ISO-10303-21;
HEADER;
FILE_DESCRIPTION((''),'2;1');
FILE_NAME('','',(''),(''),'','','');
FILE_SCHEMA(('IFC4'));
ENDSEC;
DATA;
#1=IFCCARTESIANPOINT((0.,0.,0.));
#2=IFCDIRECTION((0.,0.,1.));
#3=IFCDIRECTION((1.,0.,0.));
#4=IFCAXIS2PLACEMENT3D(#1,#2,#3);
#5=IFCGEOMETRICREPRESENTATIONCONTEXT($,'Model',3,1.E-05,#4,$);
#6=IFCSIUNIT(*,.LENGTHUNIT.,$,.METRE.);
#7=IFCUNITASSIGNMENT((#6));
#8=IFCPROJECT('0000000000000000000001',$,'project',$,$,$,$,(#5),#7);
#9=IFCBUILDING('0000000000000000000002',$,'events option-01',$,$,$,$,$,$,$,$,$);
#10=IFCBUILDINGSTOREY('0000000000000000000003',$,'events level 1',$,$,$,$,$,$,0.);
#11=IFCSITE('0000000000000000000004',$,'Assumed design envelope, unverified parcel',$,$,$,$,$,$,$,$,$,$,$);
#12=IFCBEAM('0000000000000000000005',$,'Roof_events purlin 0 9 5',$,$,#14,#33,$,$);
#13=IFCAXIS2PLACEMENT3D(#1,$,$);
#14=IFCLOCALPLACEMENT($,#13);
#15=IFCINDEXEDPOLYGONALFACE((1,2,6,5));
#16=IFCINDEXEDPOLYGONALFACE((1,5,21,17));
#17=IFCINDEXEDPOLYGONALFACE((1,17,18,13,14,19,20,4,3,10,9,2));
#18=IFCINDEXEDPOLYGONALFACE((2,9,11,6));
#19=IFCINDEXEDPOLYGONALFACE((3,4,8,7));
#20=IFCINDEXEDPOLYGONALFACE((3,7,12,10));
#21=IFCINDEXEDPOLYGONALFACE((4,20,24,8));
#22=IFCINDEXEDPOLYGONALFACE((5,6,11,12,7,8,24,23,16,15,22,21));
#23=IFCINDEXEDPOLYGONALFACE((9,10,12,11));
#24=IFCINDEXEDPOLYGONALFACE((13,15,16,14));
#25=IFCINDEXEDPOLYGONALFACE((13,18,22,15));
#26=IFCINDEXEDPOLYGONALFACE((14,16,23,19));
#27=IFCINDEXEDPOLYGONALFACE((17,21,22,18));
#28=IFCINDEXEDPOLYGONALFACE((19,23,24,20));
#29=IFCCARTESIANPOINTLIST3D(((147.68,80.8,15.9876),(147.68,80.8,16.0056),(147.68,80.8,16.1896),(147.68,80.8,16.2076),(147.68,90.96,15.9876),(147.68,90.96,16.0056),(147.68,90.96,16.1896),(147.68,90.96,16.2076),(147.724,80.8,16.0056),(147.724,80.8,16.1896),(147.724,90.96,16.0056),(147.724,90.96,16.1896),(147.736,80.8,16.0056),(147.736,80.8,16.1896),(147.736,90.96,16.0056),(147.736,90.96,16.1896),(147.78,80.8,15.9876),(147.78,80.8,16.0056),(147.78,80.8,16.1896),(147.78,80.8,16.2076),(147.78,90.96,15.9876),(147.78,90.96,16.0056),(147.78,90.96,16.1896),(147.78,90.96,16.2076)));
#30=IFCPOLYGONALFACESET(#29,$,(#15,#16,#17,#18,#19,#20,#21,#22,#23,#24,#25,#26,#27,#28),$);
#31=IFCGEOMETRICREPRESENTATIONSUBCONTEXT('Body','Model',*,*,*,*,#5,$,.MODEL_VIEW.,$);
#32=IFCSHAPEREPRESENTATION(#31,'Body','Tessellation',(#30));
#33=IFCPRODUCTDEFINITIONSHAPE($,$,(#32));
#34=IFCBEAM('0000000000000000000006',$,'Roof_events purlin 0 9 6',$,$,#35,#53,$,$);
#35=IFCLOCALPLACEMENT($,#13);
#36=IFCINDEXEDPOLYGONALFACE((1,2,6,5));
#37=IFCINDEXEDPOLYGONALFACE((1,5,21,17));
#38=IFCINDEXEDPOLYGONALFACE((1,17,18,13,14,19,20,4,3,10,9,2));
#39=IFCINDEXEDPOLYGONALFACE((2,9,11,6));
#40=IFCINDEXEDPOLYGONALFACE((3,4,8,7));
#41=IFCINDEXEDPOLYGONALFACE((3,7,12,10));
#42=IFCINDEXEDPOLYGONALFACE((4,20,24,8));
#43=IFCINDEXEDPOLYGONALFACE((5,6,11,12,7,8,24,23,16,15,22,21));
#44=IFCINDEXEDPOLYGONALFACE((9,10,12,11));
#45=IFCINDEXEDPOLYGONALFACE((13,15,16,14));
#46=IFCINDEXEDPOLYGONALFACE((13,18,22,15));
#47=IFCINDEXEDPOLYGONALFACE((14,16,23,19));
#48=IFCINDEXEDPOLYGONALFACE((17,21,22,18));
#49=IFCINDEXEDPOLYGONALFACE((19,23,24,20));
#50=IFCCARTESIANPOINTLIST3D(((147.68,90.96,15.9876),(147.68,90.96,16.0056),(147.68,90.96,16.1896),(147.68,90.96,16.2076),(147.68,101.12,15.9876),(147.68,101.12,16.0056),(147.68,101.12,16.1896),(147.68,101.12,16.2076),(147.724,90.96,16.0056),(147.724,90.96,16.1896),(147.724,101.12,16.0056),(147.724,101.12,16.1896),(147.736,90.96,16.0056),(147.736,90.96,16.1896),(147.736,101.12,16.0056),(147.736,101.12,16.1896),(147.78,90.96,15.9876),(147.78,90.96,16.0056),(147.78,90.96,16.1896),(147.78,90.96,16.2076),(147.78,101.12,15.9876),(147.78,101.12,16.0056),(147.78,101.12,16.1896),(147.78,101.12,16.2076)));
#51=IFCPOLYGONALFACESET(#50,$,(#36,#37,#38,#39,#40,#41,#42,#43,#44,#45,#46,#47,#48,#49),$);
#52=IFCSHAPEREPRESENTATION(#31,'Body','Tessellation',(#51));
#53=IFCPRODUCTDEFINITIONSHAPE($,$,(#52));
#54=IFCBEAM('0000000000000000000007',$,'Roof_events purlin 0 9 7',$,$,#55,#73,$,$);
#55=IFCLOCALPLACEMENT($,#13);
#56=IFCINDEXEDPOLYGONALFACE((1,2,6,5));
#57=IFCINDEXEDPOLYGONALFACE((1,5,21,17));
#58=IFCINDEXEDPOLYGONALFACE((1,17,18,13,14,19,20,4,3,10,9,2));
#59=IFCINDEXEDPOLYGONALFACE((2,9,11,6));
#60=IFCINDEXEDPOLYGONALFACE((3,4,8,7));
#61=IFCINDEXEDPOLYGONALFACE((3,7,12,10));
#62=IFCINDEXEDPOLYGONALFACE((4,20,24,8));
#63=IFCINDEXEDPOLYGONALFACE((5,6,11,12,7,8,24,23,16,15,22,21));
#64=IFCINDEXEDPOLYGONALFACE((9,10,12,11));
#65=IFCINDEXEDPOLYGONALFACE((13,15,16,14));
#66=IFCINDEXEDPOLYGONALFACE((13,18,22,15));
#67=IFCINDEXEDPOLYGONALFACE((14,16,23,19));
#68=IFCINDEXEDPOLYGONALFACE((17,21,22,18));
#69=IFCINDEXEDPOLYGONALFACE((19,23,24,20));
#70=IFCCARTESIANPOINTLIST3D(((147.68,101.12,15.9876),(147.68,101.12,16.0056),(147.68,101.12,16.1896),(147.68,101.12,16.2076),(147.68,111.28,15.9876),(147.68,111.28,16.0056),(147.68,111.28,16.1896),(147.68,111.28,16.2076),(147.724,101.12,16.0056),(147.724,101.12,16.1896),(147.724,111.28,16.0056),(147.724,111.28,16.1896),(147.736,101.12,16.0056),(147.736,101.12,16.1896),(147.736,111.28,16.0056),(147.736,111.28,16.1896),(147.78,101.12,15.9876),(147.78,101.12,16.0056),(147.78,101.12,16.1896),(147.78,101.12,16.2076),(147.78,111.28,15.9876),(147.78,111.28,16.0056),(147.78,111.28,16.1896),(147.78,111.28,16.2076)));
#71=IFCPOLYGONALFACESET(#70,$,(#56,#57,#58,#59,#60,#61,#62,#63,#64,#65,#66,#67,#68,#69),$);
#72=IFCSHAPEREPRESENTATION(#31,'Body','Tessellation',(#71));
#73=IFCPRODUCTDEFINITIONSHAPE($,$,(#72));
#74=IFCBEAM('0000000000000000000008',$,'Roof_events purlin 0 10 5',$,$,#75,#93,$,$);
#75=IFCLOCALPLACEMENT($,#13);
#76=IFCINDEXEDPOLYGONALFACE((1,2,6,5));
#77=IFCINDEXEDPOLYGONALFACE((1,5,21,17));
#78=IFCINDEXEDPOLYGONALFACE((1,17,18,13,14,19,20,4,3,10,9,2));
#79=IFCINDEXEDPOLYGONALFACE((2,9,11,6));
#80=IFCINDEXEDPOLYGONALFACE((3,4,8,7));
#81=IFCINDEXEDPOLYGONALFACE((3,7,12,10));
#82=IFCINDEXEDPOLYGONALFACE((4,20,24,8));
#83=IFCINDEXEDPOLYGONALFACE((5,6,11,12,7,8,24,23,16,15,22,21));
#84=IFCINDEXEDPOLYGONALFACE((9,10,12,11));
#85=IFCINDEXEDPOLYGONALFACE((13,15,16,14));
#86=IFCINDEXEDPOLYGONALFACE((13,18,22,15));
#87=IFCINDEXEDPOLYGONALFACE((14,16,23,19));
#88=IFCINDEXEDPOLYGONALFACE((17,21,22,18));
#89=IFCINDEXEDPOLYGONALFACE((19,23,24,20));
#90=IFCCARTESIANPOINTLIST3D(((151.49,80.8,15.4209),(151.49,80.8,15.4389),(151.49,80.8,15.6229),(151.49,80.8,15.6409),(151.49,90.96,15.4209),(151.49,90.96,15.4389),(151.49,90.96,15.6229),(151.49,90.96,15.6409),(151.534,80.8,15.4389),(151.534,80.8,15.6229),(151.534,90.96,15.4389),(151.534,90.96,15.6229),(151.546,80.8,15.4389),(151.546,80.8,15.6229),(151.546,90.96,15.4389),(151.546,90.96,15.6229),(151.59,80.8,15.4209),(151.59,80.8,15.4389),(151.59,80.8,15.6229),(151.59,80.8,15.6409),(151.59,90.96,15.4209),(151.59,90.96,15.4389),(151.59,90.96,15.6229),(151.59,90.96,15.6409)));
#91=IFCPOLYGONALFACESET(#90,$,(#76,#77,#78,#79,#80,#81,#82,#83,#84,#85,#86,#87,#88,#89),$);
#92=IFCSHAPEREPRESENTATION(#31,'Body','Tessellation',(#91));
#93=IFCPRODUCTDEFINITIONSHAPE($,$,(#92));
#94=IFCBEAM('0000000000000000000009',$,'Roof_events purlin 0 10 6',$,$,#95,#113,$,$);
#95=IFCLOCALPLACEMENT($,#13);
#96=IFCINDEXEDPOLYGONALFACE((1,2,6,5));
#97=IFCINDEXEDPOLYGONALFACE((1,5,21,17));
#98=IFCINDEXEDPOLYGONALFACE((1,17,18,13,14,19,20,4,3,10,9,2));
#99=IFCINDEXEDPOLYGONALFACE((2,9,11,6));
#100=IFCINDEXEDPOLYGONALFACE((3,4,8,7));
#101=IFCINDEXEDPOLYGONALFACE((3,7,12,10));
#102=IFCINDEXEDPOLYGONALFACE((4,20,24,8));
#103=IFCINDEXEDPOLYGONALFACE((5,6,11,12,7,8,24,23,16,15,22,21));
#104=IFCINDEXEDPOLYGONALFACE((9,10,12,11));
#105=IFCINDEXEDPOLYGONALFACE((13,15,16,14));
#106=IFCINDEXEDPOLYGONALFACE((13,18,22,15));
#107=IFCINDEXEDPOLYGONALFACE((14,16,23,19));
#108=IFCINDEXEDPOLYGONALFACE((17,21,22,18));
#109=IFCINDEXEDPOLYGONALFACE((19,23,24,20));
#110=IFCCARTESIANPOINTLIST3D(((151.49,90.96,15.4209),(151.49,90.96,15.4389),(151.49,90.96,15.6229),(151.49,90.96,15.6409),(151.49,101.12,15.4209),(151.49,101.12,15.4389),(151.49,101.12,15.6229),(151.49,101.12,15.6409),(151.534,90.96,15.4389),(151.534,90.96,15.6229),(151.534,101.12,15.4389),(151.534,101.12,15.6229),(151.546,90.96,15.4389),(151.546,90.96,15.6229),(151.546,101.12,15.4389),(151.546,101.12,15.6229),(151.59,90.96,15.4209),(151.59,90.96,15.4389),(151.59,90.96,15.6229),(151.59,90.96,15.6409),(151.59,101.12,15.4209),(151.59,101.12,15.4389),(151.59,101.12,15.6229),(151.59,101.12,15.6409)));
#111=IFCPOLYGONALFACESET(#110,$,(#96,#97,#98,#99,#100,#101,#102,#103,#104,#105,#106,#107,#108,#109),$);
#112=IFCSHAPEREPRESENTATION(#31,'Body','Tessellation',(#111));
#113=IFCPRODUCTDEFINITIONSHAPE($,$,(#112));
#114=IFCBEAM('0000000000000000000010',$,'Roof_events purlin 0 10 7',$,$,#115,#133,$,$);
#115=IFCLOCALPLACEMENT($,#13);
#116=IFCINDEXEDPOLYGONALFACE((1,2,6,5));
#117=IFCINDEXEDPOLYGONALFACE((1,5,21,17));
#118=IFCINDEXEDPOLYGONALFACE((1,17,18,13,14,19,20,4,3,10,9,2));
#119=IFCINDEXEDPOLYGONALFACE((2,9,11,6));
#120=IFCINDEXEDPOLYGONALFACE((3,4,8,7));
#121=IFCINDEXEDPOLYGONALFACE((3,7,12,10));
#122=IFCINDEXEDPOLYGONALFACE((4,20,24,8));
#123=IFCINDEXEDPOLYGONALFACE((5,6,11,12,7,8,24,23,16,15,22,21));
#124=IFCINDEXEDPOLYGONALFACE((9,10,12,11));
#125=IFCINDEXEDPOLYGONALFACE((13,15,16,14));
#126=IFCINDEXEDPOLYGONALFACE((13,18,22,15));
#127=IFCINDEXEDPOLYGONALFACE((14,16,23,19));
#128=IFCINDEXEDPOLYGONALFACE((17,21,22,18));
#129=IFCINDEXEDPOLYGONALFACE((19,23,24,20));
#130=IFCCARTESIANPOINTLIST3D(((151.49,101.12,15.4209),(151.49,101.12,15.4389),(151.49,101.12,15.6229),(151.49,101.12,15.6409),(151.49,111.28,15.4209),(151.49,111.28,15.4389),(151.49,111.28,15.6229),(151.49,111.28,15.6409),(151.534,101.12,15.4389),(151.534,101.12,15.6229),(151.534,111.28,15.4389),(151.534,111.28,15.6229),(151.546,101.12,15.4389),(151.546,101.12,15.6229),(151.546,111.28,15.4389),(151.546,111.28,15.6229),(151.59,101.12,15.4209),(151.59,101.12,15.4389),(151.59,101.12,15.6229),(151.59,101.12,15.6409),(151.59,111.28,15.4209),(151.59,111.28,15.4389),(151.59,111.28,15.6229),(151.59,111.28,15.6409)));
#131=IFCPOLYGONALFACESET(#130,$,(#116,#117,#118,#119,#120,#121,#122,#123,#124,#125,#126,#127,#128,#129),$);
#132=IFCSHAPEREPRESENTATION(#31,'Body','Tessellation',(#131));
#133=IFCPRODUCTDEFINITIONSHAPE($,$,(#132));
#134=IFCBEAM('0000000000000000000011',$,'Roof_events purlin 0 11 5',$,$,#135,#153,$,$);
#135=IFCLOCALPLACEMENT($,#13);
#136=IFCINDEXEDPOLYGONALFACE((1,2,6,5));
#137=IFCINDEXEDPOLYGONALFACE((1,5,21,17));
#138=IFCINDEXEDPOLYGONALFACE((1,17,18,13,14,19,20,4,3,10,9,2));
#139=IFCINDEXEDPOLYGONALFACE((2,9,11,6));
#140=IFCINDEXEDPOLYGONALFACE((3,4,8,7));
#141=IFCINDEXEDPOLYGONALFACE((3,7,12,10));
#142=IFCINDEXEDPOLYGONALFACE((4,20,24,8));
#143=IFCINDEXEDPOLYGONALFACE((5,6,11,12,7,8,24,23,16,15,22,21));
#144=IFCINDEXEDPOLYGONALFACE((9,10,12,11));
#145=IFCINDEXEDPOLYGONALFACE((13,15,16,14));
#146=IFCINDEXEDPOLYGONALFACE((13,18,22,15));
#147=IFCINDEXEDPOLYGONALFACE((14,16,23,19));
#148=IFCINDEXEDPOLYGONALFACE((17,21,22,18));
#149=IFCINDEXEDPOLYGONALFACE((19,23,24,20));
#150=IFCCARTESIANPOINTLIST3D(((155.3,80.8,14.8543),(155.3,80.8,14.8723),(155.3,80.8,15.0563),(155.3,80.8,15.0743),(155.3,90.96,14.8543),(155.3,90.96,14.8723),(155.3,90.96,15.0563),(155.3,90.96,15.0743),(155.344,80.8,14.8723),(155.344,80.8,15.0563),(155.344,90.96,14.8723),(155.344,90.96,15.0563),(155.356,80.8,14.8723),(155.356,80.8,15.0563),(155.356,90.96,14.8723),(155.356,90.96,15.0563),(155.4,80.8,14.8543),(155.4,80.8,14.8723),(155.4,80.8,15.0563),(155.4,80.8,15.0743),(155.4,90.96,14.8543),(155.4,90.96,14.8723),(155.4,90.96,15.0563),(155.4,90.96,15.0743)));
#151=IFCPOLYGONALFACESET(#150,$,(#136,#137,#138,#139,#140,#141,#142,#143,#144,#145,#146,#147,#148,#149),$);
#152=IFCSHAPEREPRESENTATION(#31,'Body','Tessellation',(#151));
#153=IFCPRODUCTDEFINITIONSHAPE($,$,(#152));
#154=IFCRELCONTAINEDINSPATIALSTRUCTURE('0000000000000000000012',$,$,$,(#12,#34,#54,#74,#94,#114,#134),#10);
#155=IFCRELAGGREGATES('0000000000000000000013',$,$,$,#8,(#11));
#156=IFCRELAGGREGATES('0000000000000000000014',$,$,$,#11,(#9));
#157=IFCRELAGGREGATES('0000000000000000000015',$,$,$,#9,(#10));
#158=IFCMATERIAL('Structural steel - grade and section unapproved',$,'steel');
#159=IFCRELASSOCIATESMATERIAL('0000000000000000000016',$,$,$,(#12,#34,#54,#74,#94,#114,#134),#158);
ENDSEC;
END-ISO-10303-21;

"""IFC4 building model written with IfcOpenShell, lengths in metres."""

from ifc_helpers import new_model, si_unit, frame, origin_with_axes, place, context, subcontext, project, spatial, i_section, extrude, material, element, save


model = new_model("IFC4")

# Units and contexts
model_context = context("Model", 3, precision=1e-05, world=origin_with_axes())
body_context = subcontext(model_context, "Body", "Model", "MODEL_VIEW")
ifc_project = project(units=[si_unit("LENGTHUNIT", "METRE")], contexts=[model_context])

# Site, building, storey
site = spatial("IfcSite", under=ifc_project, Name="Assumed design envelope, unverified parcel")
building = spatial("IfcBuilding", under=site, Name="events option-01")
storey = spatial("IfcBuildingStorey", under=building, Name="events level 1", Elevation=0.0)

# Beams
ifc_material = material(Name="Structural steel - grade and section unapproved", Category="steel")
for number, where, z_axis, x_axis, name in (
    (1, (147.73, 80.8, 16.0976), (0.0, 1.0, 0.0), (-1.0, 0.0, 0.0), "Roof_events purlin 0 9 5"),
):
    element("IfcBeam", number, at=place(None, frame(where, z_axis=z_axis, x_axis=x_axis)), inside=storey, material=ifc_material, Name=name, context=body_context, shape_type="SweptSolid", body=[
        extrude(i_section(OverallWidth=0.1, OverallDepth=0.22, WebThickness=0.012, FlangeThickness=0.018, FilletRadius=0.0), origin_with_axes(), (0.0, 0.0, 1.0), 10.16),
    ])
beam_1_placement = place(None, frame((147.73, 90.96, 16.0976), z_axis=(0.0, 1.0, 0.0), x_axis=(-1.0, 0.0, 0.0)))
element("IfcBeam", 2, at=beam_1_placement, inside=storey, material=ifc_material, Name="Roof_events purlin 0 9 6", context=body_context, shape_type="SweptSolid", body=[
    extrude(i_section(OverallWidth=0.1, OverallDepth=0.22, WebThickness=0.012, FlangeThickness=0.018, FilletRadius=0.0), origin_with_axes(), (0.0, 0.0, 1.0), 10.16),
])
for number, where, z_axis, x_axis, name in (
    (3, (147.73, 101.12, 16.0976), (0.0, 1.0, 0.0), (-1.0, 0.0, 0.0), "Roof_events purlin 0 9 7"),
    (4, (151.54, 80.8, 15.5309), (0.0, 1.0, 0.0), (-1.0, 0.0, 0.0), "Roof_events purlin 0 10 5"),
):
    element("IfcBeam", number, at=place(None, frame(where, z_axis=z_axis, x_axis=x_axis)), inside=storey, material=ifc_material, Name=name, context=body_context, shape_type="SweptSolid", body=[
        extrude(i_section(OverallWidth=0.1, OverallDepth=0.22, WebThickness=0.012, FlangeThickness=0.018, FilletRadius=0.0), origin_with_axes(), (0.0, 0.0, 1.0), 10.16),
    ])
beam_2_placement = place(None, frame((151.54, 90.96, 15.5309), z_axis=(0.0, 1.0, 0.0), x_axis=(-1.0, 0.0, 0.0)))
element("IfcBeam", 5, at=beam_2_placement, inside=storey, material=ifc_material, Name="Roof_events purlin 0 10 6", context=body_context, shape_type="SweptSolid", body=[
    extrude(i_section(OverallWidth=0.1, OverallDepth=0.22, WebThickness=0.012, FlangeThickness=0.018, FilletRadius=0.0), origin_with_axes(), (0.0, 0.0, 1.0), 10.16),
])
for number, where, z_axis, x_axis, name in (
    (6, (151.54, 101.12, 15.5309), (0.0, 1.0, 0.0), (-1.0, 0.0, 0.0), "Roof_events purlin 0 10 7"),
    (7, (155.35, 80.8, 14.9643), (0.0, 1.0, 0.0), (-1.0, 0.0, 0.0), "Roof_events purlin 0 11 5"),
):
    element("IfcBeam", number, at=place(None, frame(where, z_axis=z_axis, x_axis=x_axis)), inside=storey, material=ifc_material, Name=name, context=body_context, shape_type="SweptSolid", body=[
        extrude(i_section(OverallWidth=0.1, OverallDepth=0.22, WebThickness=0.012, FlangeThickness=0.018, FilletRadius=0.0), origin_with_axes(), (0.0, 0.0, 1.0), 10.16),
    ])

save(model, "model.ifc")
